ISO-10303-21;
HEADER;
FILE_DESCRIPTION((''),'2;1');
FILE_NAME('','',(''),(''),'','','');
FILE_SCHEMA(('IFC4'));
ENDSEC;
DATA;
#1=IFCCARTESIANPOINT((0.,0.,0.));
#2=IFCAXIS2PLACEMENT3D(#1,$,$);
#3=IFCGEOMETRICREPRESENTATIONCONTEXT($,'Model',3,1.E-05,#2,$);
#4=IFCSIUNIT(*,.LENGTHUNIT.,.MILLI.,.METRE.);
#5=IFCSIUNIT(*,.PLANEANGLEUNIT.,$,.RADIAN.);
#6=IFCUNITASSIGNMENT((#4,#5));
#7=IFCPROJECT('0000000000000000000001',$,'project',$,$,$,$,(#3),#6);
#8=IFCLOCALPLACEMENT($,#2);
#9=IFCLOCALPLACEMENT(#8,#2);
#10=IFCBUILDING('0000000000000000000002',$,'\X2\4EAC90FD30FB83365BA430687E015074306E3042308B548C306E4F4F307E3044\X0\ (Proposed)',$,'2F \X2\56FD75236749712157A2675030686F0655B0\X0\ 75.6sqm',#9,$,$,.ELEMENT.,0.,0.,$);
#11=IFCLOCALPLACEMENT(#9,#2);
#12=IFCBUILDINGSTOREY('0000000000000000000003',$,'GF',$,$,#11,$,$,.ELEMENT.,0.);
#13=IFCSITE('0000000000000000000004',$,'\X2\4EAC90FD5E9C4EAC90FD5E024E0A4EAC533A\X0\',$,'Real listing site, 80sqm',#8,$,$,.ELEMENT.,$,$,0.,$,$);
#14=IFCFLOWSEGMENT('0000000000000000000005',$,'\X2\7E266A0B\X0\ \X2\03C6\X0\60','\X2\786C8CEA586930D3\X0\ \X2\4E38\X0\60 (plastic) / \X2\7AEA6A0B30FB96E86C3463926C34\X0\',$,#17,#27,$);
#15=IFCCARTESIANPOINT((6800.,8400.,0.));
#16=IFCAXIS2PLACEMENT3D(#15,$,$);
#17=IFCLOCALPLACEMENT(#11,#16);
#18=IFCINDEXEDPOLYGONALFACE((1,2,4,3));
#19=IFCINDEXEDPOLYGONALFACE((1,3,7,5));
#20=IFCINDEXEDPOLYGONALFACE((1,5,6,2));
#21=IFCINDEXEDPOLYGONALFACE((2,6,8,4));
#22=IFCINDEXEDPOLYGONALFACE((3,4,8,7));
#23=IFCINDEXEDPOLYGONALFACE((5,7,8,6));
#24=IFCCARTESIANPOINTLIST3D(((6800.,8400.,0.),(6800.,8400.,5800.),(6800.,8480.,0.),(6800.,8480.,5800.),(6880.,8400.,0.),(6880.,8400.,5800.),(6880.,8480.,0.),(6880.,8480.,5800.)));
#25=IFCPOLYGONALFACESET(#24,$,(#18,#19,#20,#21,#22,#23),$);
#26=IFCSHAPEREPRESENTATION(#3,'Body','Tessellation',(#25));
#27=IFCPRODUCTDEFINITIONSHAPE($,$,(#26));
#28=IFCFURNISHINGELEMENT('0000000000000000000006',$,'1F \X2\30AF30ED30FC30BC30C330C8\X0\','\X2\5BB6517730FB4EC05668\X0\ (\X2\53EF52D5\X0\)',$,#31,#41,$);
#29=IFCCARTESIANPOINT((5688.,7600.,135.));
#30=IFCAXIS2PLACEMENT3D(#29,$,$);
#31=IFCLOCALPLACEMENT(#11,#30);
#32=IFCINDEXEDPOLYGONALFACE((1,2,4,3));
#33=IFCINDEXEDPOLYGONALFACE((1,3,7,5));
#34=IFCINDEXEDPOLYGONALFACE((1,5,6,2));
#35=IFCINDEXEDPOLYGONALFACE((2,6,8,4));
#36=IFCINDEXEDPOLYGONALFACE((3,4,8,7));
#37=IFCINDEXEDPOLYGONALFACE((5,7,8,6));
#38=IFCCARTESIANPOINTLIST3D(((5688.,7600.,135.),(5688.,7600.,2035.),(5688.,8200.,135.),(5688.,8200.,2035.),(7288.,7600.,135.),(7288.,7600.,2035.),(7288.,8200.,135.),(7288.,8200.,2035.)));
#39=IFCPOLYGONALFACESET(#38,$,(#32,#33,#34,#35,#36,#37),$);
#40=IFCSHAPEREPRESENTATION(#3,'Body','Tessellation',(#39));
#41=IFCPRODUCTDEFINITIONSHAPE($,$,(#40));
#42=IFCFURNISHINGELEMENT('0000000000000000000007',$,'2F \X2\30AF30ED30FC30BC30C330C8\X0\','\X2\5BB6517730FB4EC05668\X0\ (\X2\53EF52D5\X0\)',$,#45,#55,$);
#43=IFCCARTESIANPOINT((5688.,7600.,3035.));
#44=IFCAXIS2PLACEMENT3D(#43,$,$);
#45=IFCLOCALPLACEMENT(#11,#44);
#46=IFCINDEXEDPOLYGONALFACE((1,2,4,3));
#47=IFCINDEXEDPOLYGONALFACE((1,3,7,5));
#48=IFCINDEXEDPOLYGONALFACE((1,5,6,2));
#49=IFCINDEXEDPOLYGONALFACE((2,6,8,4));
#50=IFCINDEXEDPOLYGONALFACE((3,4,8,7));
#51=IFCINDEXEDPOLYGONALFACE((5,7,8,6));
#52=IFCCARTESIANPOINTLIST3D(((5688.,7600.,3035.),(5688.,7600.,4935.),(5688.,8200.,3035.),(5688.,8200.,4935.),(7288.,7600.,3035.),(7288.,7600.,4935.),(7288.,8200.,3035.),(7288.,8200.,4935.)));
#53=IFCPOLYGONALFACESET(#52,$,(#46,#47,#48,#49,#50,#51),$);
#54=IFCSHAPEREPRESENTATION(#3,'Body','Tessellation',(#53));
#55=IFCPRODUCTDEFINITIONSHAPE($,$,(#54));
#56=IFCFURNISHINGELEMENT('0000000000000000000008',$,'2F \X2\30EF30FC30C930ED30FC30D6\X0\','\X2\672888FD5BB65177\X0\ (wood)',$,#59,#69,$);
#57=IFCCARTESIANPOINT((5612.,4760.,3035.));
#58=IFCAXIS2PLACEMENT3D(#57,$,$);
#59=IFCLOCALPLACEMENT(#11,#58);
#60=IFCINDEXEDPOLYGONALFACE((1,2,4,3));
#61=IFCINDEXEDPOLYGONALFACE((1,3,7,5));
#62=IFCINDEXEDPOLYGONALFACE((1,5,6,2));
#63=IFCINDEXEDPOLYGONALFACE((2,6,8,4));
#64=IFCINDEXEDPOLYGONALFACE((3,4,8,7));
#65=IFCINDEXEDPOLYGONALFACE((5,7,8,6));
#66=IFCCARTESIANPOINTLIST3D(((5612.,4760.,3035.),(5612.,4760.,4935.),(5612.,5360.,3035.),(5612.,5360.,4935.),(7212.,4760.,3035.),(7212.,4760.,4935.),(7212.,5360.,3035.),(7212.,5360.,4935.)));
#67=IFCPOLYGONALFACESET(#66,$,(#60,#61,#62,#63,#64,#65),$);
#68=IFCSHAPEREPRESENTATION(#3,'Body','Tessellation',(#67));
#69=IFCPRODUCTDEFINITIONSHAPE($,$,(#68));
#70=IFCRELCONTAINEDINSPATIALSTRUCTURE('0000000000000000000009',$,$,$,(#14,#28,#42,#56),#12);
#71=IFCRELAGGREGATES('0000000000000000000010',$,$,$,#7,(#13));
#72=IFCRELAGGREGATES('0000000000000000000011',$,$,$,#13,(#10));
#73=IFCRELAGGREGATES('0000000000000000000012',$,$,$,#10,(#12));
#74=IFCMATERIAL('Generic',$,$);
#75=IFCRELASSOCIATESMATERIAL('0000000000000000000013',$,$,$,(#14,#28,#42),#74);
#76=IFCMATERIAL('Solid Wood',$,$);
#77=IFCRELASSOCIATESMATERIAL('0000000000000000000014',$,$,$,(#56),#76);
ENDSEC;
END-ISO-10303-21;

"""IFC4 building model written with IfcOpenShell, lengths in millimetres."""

from ifc_helpers import new_model, si_unit, frame, frame_2d, origin, place, context, project, spatial, rectangle, extrude, material, element, save


model = new_model("IFC4")

# Units and contexts
model_context = context("Model", 3, precision=1e-05, world=origin())
ifc_project = project(units=[si_unit("LENGTHUNIT", "METRE", prefix="MILLI"), si_unit("PLANEANGLEUNIT", "RADIAN")], contexts=[model_context])

# Site, building, storey
site_placement = place(None, origin())
site = spatial("IfcSite", under=ifc_project, at=site_placement, Name="京都府京都市上京区", ObjectType="Real listing site, 80sqm", CompositionType="ELEMENT", RefElevation=0.0)
building_placement = place(site_placement, origin())
building = spatial("IfcBuilding", under=site, at=building_placement, Name="京都・茶室と縁側のある和の住まい (Proposed)", ObjectType="2F 国産杉無垢材と漆喰 75.6sqm", CompositionType="ELEMENT", ElevationOfRefHeight=0.0, ElevationOfTerrain=0.0)
storey_placement = place(building_placement, origin())
storey = spatial("IfcBuildingStorey", under=building, at=storey_placement, Name="GF", CompositionType="ELEMENT", Elevation=0.0)

# Shared definitions
ifc_material_1 = material(Name="Solid Wood")

# Shared definitions
ifc_material_2 = material(Name="Generic")

# Flow segment
flow_segment_placement = place(storey_placement, frame((6800.0, 8400.0, 0.0)))
element("IfcFlowSegment", 1, at=flow_segment_placement, inside=storey, material=ifc_material_2, Name="縦樋 φ60", Description="硬質塩ビ 丸60 (plastic) / 竪樋・雨水排水", context=model_context, shape_type="SweptSolid", body=[
    extrude(rectangle(XDim=80.0, YDim=80.0, at=frame_2d((40.0, 40.0))), frame((6800.0, 8400.0, 0.0)), (0.0, 0.0, 1.0), 5800.0),
])

# Furnishing elements
furnishing_1_placement = place(storey_placement, frame((5688.0, 7600.0, 135.0)))
element("IfcFurnishingElement", 2, at=furnishing_1_placement, inside=storey, material=ifc_material_2, Name="1F クローゼット", Description="家具・什器 (可動)", context=model_context, shape_type="SweptSolid", body=[
    extrude(rectangle(XDim=1600.0, YDim=600.0, at=frame_2d((800.0, 300.0))), frame((5688.0, 7600.0, 135.0)), (0.0, 0.0, 1.0), 1900.0),
])
furnishing_2_placement = place(storey_placement, frame((5688.0, 7600.0, 3035.0)))
element("IfcFurnishingElement", 3, at=furnishing_2_placement, inside=storey, material=ifc_material_2, Name="2F クローゼット", Description="家具・什器 (可動)", context=model_context, shape_type="SweptSolid", body=[
    extrude(rectangle(XDim=1600.0, YDim=600.0, at=frame_2d((800.0, 300.0))), frame((5688.0, 7600.0, 3035.0)), (0.0, 0.0, 1.0), 1900.0),
])
furnishing_3_placement = place(storey_placement, frame((5612.0, 4760.0, 3035.0)))
element("IfcFurnishingElement", 4, at=furnishing_3_placement, inside=storey, material=ifc_material_1, Name="2F ワードローブ", Description="木製家具 (wood)", context=model_context, shape_type="SweptSolid", body=[
    extrude(rectangle(XDim=1600.0, YDim=600.0, at=frame_2d((800.0, 300.0))), frame((5612.0, 4760.0, 3035.0)), (0.0, 0.0, 1.0), 1900.0),
])

save(model, "model.ifc")
